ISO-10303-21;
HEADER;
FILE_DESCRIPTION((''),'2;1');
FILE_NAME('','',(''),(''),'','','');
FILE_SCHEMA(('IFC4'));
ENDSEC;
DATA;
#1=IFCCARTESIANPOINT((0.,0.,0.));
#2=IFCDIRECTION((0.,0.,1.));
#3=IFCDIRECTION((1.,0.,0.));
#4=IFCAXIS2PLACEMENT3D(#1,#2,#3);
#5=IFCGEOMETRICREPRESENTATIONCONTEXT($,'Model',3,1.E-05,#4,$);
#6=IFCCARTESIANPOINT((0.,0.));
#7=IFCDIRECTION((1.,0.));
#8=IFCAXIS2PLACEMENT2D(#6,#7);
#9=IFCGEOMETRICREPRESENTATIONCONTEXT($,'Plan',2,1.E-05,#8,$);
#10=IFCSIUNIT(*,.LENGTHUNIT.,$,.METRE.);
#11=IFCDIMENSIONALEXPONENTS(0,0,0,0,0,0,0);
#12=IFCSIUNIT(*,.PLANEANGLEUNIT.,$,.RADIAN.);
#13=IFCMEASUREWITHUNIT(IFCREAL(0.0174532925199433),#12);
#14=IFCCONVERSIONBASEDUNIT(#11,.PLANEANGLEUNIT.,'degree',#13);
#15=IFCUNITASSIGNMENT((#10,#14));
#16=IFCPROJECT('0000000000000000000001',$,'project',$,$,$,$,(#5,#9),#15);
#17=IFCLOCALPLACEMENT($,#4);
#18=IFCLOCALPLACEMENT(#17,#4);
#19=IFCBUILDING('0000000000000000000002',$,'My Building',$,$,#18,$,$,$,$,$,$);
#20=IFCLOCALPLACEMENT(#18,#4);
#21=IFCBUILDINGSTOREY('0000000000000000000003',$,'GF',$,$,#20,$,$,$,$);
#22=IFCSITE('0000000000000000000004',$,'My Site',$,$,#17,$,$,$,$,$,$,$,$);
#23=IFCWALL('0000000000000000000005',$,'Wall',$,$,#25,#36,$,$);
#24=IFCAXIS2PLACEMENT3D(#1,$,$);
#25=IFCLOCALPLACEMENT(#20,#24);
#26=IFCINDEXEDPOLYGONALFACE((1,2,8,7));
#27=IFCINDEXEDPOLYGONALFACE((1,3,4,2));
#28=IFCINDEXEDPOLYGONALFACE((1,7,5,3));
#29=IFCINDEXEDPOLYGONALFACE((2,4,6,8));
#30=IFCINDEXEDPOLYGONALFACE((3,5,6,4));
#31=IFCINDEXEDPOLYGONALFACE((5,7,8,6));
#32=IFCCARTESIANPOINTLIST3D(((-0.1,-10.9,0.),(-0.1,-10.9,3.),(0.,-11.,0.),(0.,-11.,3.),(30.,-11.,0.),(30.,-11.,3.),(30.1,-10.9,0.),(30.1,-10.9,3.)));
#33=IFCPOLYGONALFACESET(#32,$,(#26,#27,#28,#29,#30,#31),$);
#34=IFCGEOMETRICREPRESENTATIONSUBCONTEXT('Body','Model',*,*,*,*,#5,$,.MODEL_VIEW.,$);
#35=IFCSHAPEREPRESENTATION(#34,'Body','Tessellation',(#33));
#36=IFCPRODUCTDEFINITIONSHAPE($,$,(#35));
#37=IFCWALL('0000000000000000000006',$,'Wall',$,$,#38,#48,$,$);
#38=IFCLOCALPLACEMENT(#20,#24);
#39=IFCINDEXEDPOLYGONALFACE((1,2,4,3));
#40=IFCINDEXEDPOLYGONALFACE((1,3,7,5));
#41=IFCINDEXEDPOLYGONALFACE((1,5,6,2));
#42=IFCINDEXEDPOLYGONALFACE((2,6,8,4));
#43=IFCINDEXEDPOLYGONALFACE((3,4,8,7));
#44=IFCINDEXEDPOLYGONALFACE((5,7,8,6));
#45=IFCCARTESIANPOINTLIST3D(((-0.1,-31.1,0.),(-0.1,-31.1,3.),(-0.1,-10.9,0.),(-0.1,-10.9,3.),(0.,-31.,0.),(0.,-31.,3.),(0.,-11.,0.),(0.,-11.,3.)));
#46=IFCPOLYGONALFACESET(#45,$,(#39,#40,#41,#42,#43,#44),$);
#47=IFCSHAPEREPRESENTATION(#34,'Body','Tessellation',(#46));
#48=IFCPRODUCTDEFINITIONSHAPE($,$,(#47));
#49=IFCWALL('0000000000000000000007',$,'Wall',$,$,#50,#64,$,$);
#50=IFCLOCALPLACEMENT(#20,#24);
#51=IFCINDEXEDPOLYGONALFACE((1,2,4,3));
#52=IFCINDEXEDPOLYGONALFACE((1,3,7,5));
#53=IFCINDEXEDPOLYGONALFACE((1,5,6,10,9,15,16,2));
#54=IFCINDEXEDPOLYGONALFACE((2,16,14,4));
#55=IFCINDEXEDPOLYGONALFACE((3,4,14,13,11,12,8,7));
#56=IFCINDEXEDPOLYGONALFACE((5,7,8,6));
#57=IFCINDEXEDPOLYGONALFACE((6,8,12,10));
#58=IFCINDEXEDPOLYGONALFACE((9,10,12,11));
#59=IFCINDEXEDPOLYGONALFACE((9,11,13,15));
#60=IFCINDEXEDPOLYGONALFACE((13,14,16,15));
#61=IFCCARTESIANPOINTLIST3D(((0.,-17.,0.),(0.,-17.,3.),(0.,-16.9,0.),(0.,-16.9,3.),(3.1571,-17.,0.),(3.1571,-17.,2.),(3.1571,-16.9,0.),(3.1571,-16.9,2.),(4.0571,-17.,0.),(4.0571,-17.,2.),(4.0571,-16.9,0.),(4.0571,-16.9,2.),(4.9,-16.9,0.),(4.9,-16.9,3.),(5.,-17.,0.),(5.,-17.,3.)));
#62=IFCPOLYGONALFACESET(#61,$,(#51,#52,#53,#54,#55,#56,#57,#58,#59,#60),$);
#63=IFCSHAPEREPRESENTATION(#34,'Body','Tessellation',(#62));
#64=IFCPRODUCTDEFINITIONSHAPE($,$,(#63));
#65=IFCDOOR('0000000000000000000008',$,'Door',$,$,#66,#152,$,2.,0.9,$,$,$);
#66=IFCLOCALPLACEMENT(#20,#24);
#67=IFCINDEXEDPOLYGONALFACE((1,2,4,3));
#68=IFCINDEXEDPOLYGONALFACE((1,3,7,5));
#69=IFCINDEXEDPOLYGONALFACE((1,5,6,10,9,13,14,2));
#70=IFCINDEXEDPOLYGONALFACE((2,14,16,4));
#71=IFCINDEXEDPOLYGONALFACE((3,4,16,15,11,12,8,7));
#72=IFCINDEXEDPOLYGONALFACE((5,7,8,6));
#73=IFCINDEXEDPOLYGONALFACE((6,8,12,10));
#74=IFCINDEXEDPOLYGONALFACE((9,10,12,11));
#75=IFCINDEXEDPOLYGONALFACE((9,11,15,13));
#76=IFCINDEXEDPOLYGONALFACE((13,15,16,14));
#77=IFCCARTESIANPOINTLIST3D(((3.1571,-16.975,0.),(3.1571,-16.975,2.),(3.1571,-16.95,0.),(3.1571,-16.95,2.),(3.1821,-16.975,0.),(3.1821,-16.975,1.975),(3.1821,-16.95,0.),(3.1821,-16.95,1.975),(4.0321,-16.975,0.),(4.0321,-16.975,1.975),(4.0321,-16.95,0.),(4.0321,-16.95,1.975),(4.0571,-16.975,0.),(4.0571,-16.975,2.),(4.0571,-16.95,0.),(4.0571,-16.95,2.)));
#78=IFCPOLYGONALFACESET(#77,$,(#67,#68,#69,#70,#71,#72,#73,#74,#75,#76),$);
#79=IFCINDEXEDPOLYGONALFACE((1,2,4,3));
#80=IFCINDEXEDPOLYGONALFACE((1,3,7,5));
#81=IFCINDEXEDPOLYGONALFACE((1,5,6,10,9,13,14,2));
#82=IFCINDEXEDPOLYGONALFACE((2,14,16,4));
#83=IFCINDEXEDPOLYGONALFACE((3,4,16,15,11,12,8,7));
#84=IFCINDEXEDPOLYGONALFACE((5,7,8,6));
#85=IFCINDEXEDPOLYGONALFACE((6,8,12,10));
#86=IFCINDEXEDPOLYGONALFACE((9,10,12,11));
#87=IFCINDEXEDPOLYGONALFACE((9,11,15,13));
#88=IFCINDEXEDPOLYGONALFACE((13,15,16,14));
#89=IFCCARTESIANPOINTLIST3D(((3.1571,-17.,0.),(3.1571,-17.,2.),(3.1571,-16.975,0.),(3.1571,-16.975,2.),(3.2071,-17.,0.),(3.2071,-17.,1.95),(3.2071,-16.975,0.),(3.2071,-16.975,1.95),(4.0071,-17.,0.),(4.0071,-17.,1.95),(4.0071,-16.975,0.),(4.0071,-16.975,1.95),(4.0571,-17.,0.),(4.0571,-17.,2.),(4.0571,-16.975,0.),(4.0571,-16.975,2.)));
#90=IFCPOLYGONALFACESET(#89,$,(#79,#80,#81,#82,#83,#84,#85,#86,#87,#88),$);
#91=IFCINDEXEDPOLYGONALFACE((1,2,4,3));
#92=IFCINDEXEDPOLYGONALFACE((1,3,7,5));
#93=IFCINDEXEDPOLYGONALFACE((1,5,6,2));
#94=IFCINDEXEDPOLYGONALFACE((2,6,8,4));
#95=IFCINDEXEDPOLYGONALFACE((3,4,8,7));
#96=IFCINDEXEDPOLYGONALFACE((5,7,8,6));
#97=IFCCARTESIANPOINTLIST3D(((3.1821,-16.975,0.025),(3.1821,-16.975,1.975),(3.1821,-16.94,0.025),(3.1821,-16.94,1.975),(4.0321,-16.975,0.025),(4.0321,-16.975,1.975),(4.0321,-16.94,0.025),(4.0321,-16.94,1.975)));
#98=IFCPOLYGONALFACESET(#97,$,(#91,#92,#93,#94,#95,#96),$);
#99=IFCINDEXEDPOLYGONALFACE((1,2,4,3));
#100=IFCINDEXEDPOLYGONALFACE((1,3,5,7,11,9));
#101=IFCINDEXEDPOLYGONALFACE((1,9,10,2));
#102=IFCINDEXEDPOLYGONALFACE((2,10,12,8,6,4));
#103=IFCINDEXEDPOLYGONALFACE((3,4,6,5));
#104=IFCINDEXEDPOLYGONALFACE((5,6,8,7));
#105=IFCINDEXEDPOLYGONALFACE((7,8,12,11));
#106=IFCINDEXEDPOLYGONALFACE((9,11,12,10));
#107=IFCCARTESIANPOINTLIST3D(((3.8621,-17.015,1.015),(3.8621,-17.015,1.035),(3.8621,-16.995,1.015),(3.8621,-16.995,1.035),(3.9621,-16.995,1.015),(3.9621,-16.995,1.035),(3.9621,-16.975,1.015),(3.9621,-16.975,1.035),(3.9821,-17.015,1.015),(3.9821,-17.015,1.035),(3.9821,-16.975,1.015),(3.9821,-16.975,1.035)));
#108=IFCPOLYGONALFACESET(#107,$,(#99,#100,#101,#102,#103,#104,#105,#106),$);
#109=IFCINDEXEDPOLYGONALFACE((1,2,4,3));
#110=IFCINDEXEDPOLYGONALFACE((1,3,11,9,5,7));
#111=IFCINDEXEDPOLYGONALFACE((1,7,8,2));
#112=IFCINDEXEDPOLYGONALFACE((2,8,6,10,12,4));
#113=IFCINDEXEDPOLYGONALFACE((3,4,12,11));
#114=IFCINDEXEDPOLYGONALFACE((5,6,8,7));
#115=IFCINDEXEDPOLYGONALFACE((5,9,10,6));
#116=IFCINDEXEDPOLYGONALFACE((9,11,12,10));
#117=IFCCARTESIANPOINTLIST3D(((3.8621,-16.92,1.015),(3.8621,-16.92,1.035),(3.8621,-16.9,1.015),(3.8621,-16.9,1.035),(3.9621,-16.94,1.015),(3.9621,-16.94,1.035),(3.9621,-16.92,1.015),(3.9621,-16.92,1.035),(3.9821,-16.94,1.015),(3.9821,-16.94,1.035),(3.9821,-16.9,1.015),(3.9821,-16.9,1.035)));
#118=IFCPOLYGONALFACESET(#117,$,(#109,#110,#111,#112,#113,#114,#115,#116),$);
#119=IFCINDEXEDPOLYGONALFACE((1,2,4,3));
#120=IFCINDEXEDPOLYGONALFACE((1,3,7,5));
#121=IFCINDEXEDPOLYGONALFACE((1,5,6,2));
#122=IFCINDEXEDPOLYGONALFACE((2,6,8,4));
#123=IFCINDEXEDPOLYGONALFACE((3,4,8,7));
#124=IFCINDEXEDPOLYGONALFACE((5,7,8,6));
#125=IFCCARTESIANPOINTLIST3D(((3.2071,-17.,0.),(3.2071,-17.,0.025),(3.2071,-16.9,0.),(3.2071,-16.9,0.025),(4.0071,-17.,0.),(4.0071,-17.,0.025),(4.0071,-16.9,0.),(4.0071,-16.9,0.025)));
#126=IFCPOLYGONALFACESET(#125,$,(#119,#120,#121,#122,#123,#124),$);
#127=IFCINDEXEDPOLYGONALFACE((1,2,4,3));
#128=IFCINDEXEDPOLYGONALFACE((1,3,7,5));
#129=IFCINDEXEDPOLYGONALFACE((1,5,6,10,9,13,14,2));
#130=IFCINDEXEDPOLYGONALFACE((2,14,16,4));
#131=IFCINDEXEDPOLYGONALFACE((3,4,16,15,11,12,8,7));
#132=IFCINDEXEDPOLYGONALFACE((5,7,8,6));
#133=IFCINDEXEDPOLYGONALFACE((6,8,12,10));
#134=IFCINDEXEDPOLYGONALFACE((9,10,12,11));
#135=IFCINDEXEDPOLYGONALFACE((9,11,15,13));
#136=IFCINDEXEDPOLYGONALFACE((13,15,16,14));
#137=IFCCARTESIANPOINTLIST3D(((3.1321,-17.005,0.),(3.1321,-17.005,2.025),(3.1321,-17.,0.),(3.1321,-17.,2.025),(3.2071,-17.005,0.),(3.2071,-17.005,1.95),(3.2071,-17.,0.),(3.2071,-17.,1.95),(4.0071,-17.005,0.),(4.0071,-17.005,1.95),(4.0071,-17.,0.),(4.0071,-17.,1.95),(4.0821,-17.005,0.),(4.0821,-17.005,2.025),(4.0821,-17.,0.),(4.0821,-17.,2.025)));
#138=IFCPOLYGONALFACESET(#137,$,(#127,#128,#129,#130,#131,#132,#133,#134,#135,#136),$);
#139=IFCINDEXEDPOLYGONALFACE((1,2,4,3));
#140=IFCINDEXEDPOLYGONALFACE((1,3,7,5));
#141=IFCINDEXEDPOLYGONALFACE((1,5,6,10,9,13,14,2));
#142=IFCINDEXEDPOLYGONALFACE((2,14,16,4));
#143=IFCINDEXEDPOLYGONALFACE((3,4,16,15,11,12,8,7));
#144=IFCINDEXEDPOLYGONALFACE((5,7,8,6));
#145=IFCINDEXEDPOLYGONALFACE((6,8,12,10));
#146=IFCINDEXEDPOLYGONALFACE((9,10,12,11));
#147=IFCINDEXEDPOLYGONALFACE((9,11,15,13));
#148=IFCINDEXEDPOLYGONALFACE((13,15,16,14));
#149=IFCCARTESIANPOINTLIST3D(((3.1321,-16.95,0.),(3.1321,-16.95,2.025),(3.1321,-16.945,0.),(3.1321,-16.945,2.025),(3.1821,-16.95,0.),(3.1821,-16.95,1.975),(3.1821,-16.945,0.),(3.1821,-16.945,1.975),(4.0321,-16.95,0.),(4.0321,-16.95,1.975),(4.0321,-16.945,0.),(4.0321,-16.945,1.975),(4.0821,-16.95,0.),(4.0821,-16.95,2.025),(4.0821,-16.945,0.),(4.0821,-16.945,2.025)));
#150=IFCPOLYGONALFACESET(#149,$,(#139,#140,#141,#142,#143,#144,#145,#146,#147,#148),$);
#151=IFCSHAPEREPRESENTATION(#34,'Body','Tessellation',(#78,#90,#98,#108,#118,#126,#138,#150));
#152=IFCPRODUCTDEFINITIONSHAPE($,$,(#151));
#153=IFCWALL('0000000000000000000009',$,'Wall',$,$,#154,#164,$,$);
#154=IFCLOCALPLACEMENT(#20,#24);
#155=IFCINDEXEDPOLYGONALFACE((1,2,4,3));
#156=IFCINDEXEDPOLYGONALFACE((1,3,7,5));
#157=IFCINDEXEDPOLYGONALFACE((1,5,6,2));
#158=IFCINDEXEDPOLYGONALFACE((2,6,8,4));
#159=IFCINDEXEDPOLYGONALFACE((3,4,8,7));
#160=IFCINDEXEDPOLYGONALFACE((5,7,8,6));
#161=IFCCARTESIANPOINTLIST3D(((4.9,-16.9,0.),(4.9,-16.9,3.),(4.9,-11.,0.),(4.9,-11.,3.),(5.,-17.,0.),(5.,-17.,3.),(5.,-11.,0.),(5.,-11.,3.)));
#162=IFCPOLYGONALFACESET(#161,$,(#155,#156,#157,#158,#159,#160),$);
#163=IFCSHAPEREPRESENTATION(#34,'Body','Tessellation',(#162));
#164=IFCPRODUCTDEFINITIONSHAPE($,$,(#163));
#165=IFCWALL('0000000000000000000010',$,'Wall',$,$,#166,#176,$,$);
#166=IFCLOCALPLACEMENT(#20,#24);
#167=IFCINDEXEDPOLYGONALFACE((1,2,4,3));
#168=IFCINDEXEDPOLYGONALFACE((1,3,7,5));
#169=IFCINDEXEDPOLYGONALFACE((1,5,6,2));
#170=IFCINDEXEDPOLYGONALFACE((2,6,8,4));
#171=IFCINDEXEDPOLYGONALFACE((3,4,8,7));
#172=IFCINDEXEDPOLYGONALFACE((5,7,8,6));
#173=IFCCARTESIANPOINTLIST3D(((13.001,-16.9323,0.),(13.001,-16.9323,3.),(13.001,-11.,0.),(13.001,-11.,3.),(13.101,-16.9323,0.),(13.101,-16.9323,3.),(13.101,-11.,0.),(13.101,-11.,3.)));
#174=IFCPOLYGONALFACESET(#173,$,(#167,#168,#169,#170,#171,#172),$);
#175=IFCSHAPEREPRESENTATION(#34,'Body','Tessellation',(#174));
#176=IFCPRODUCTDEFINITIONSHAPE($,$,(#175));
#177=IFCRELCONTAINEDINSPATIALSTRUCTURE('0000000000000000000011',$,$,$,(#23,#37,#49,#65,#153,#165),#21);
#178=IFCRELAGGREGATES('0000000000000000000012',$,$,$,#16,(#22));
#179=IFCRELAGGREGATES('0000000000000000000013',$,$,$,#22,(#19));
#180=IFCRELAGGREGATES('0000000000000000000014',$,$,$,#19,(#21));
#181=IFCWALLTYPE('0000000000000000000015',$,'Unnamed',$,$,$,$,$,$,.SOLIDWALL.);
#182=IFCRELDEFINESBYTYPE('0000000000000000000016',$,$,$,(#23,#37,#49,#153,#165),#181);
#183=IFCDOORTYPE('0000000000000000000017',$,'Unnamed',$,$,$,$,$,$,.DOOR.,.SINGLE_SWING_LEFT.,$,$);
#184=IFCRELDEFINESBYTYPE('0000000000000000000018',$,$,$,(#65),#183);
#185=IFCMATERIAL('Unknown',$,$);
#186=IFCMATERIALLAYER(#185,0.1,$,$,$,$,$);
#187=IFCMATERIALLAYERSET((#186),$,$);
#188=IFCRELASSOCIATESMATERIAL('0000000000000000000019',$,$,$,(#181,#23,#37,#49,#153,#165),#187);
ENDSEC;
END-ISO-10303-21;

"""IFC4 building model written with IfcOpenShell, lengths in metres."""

from ifc_helpers import new_model, entity, si_unit, converted_unit, frame, origin_with_axes, origin_2d_with_axis, place, context, subcontext, project, spatial, line, indexed_curve, outline, extrude, shape, source, transform, mapped, material, layer, layer_set, layer_usage, type_object, type_shapes, element, fill, save


model = new_model("IFC4")

# Units and contexts
model_context = context("Model", 3, precision=1e-05, world=origin_with_axes())
plan_context = context("Plan", 2, precision=1e-05, world=origin_2d_with_axis())
body_context_1 = subcontext(model_context, "Body", "Model", "MODEL_VIEW")
body_context_2 = subcontext(plan_context, "Body", "Plan", "PLAN_VIEW")
ifc_project = project(units=[si_unit("LENGTHUNIT", "METRE"), converted_unit("PLANEANGLEUNIT", "degree", entity("IfcReal", 0.0174532925199433), si_unit("PLANEANGLEUNIT", "RADIAN"), dimensions=[0, 0, 0, 0, 0, 0, 0])], contexts=[model_context, plan_context])

# Site, building, storey
site_placement = place(None, origin_with_axes())
site = spatial("IfcSite", under=ifc_project, at=site_placement, Name="My Site")
building_placement = place(site_placement, origin_with_axes())
building = spatial("IfcBuilding", under=site, at=building_placement, Name="My Building")
storey_placement = place(building_placement, origin_with_axes())
storey = spatial("IfcBuildingStorey", under=building, at=storey_placement, Name="GF")

# Walls
ifc_material = material(Name="Unknown")
ifc_layer = layer(ifc_material, 0.1)
ifc_layer_set = layer_set([ifc_layer])
ifc_layer_usage_1 = layer_usage(ifc_layer_set, "AXIS2", "POSITIVE", 0.0)
wall_type = type_object("IfcWallType", Name="Unnamed", PredefinedType="SOLIDWALL", material=ifc_layer_set)
wall_1_placement = place(storey_placement, frame((0.0, -11.0, 0.0), z_axis=(0.0, 0.0, 1.0), x_axis=(1.0, 0.0, 0.0)))
element("IfcWall", 1, at=wall_1_placement, inside=storey, type_object=wall_type, material=ifc_layer_usage_1, Name="Wall", context=body_context_1, shape_type="SweptSolid", body=[
    extrude(outline(indexed_curve([(0.0, 0.0), (-0.1, 0.1), (30.1, 0.1), (30.0, 0.0)], segments=[line(1, 2, 3, 4, 1)])), origin_with_axes(), (0.0, 0.0, 1.0), 3.0),
])
ifc_layer_usage_2 = layer_usage(ifc_layer_set, "AXIS2", "POSITIVE", 0.0)
wall_2_placement = place(storey_placement, frame((0.0, -31.0, 0.0), z_axis=(0.0, 0.0, 1.0), x_axis=(0.0, 1.0, 0.0)))
element("IfcWall", 2, at=wall_2_placement, inside=storey, type_object=wall_type, material=ifc_layer_usage_2, Name="Wall", context=body_context_1, shape_type="SweptSolid", body=[
    extrude(outline(indexed_curve([(0.0, 0.0), (-0.1, 0.1), (20.1, 0.1), (20.0, 0.0)], segments=[line(1, 2, 3, 4, 1)])), origin_with_axes(), (0.0, 0.0, 1.0), 3.0),
])

# Wall, opening, door
ifc_layer_usage_3 = layer_usage(ifc_layer_set, "AXIS2", "POSITIVE", 0.0)
wall_3_placement = place(storey_placement, frame((0.0, -17.0, 0.0), z_axis=(0.0, 0.0, 1.0), x_axis=(1.0, 0.0, 0.0)))
wall_3 = element("IfcWall", 3, at=wall_3_placement, inside=storey, type_object=wall_type, material=ifc_layer_usage_3, Name="Wall", context=body_context_1, shape_type="SweptSolid", body=[
    extrude(outline(indexed_curve([(0.0, 0.0), (0.0, 0.1), (4.9, 0.1), (5.0, 0.0)], segments=[line(1, 2, 3, 4, 1)])), origin_with_axes(), (0.0, 0.0, 1.0), 3.0),
])
shared_shape_1 = source(origin_with_axes(), body_context_1, "Body", "SweptSolid", [
    extrude(outline(indexed_curve([(0.0, 0.0), (0.9, 0.0), (0.9, 2.0), (0.0, 2.0)], segments=[line(1, 2, 3, 4, 1)])), frame((0.0, -0.6, 0.0), z_axis=(0.0, -1.0, 0.0), x_axis=(1.0, 0.0, 0.0)), (0.0, 0.0, -1.0), 1.2),
])
opening_1_placement = place(wall_3_placement, frame((3.1571, 0.0, 0.0), z_axis=(0.0, 0.0, 1.0), x_axis=(1.0, 0.0, 0.0)))
opening_1 = element("IfcOpeningElement", 4, at=opening_1_placement, cuts=wall_3, PredefinedType="OPENING", context=body_context_1, shape_type="MappedRepresentation", body=[
    mapped(shared_shape_1, transform((0.0, 0.0, 0.0), x_axis=(1.0, 0.0, 0.0), y_axis=(0.0, 1.0, 0.0), z_axis=(0.0, 0.0, 1.0), scale=1.0)),
])
door_type = type_object("IfcDoorType", Name="Unnamed", OperationType="SINGLE_SWING_LEFT", PredefinedType="DOOR")
shared_shape_2 = source(origin_with_axes(), body_context_1, "Body", "SweptSolid", [
    extrude(outline(indexed_curve([(0.0, 0.0), (0.0, 2.0), (0.9, 2.0), (0.9, 0.0), (0.875, 0.0), (0.875, 1.975), (0.025, 1.975), (0.025, 0.0)], segments=[line(1, 2, 3, 4, 5, 6, 7, 8, 1)])), frame((0.0, 0.025, 0.0), z_axis=(0.0, -1.0, 0.0), x_axis=(1.0, 0.0, 0.0)), (0.0, 0.0, -1.0), 0.025),
    extrude(outline(indexed_curve([(0.0, 0.0), (0.0, 2.0), (0.9, 2.0), (0.9, 0.0), (0.85, 0.0), (0.85, 1.95), (0.05, 1.95), (0.05, 0.0)], segments=[line(1, 2, 3, 4, 5, 6, 7, 8, 1)])), frame((0.0, 0.0, 0.0), z_axis=(0.0, -1.0, 0.0), x_axis=(1.0, 0.0, 0.0)), (0.0, 0.0, -1.0), 0.025),
    extrude(outline(indexed_curve([(0.0, 0.0), (0.85, 0.0), (0.85, 0.035), (0.0, 0.035)], segments=[line(1, 2, 3, 4, 1)])), frame((0.025, 0.025, 0.025), z_axis=(0.0, 0.0, 1.0), x_axis=(1.0, 0.0, 0.0)), (0.0, 0.0, 1.0), 1.95),
    extrude(outline(indexed_curve([(0.0, 0.0), (0.0, -0.04), (-0.12, -0.04), (-0.12, -0.02), (-0.02, -0.02), (-0.02, 0.0)], segments=[line(1, 2, 3, 4, 5, 6, 1)])), frame((0.825, 0.025, 1.015), z_axis=(0.0, 0.0, 1.0), x_axis=(1.0, 0.0, 0.0)), (0.0, 0.0, 1.0), 0.02),
    extrude(outline(indexed_curve([(0.0, 0.0), (0.0, 0.04), (-0.12, 0.04), (-0.12, 0.02), (-0.02, 0.02), (-0.02, 0.0)], segments=[line(1, 2, 3, 4, 5, 6, 1)])), frame((0.825, 0.06, 1.015), z_axis=(0.0, 0.0, 1.0), x_axis=(1.0, 0.0, 0.0)), (0.0, 0.0, 1.0), 0.02),
    extrude(outline(indexed_curve([(0.0, 0.0), (0.8, 0.0), (0.8, 0.1), (0.0, 0.1)], segments=[line(1, 2, 3, 4, 1)])), frame((0.05, 0.0, 0.0), z_axis=(0.0, 0.0, 1.0), x_axis=(1.0, 0.0, 0.0)), (0.0, 0.0, 1.0), 0.025),
    extrude(outline(indexed_curve([(0.0, 0.0), (0.0, 2.025), (0.95, 2.025), (0.95, 0.0), (0.875, 0.0), (0.875, 1.95), (0.075, 1.95), (0.075, 0.0)], segments=[line(1, 2, 3, 4, 5, 6, 7, 8, 1)])), frame((-0.025, -0.005, 0.0), z_axis=(0.0, -1.0, 0.0), x_axis=(1.0, 0.0, 0.0)), (0.0, 0.0, -1.0), 0.005),
    extrude(outline(indexed_curve([(0.0, 0.0), (0.0, 2.025), (0.95, 2.025), (0.95, 0.0), (0.9, 0.0), (0.9, 1.975), (0.05, 1.975), (0.05, 0.0)], segments=[line(1, 2, 3, 4, 5, 6, 7, 8, 1)])), frame((-0.025, 0.05, 0.0), z_axis=(0.0, -1.0, 0.0), x_axis=(1.0, 0.0, 0.0)), (0.0, 0.0, -1.0), 0.005),
])
shared_shape_3 = source(origin_with_axes(), body_context_2, "Body", "Curve2D", [
    entity("IfcIndexedPolyCurve", entity("IfcCartesianPointList2D", [[0.0, 0.0], [0.0, 0.05], [0.025, 0.05], [0.025, 0.025], [0.05, 0.025], [0.05, 0.0]]), [entity("IfcLineIndex", [1, 2, 3, 4, 5, 6, 1])]),
    entity("IfcIndexedPolyCurve", entity("IfcCartesianPointList2D", [[0.9, 0.0], [0.9, 0.05], [0.875, 0.05], [0.875, 0.025], [0.85, 0.025], [0.85, 0.0]]), [entity("IfcLineIndex", [1, 2, 3, 4, 5, 6, 1])]),
    entity("IfcTrimmedCurve", entity("IfcEllipse", entity("IfcAxis2Placement2D", entity("IfcCartesianPoint", [0.06, 0.05]), entity("IfcDirection", [1.0, 0.0])), 0.815, 0.85), [entity("IfcCartesianPoint", [0.875, 0.05])], [entity("IfcCartesianPoint", [0.06, 0.9])], True, "CARTESIAN"),
    entity("IfcIndexedPolyCurve", entity("IfcCartesianPointList2D", [[0.025, 0.05], [0.06, 0.05], [0.06, 0.9], [0.025, 0.9]]), [entity("IfcLineIndex", [1, 2, 3, 4, 1])]),
])
type_shapes(door_type, [shared_shape_2, shared_shape_3])
door_1_placement = place(opening_1_placement, origin_with_axes())
door_1 = element("IfcDoor", 5, at=door_1_placement, inside=storey, type_object=door_type, Name="Door", OverallHeight=2.0, OverallWidth=0.9, shapes=[
    shape(body_context_1, "Body", "MappedRepresentation", [mapped(shared_shape_2, transform((0.0, 0.0, 0.0), x_axis=(1.0, 0.0, 0.0), y_axis=(0.0, 1.0, 0.0), z_axis=(0.0, 0.0, 1.0), scale=1.0))]),
    shape(body_context_2, "Body", "MappedRepresentation", [mapped(shared_shape_3, transform((0.0, 0.0, 0.0), x_axis=(1.0, 0.0, 0.0), y_axis=(0.0, 1.0, 0.0), z_axis=(0.0, 0.0, 1.0), scale=1.0))]),
])
fill(opening_1, door_1)

# Wall
ifc_layer_usage_4 = layer_usage(ifc_layer_set, "AXIS2", "POSITIVE", 0.0)
wall_4_placement = place(storey_placement, frame((5.0, -17.0, 0.0), z_axis=(0.0, 0.0, 1.0), x_axis=(0.0, 1.0, 0.0)))
element("IfcWall", 6, at=wall_4_placement, inside=storey, type_object=wall_type, material=ifc_layer_usage_4, Name="Wall", context=body_context_1, shape_type="SweptSolid", body=[
    extrude(outline(indexed_curve([(0.0, 0.0), (0.1, 0.1), (6.0, 0.1), (6.0, 0.0)], segments=[line(1, 2, 3, 4, 1)])), origin_with_axes(), (0.0, 0.0, 1.0), 3.0),
])

# Wall
ifc_layer_usage_5 = layer_usage(ifc_layer_set, "AXIS2", "POSITIVE", 0.0)
wall_5_placement = place(storey_placement, frame((13.101, -16.9323, 0.0), z_axis=(0.0, 0.0, 1.0), x_axis=(0.0, 1.0, 0.0)))
element("IfcWall", 7, at=wall_5_placement, inside=storey, type_object=wall_type, material=ifc_layer_usage_5, Name="Wall", context=body_context_1, shape_type="SweptSolid", body=[
    extrude(outline(indexed_curve([(0.0, 0.0), (0.0, 0.1), (5.9323, 0.1), (5.9323, 0.0)], segments=[line(1, 2, 3, 4, 1)])), origin_with_axes(), (0.0, 0.0, 1.0), 3.0),
])

save(model, "model.ifc")
